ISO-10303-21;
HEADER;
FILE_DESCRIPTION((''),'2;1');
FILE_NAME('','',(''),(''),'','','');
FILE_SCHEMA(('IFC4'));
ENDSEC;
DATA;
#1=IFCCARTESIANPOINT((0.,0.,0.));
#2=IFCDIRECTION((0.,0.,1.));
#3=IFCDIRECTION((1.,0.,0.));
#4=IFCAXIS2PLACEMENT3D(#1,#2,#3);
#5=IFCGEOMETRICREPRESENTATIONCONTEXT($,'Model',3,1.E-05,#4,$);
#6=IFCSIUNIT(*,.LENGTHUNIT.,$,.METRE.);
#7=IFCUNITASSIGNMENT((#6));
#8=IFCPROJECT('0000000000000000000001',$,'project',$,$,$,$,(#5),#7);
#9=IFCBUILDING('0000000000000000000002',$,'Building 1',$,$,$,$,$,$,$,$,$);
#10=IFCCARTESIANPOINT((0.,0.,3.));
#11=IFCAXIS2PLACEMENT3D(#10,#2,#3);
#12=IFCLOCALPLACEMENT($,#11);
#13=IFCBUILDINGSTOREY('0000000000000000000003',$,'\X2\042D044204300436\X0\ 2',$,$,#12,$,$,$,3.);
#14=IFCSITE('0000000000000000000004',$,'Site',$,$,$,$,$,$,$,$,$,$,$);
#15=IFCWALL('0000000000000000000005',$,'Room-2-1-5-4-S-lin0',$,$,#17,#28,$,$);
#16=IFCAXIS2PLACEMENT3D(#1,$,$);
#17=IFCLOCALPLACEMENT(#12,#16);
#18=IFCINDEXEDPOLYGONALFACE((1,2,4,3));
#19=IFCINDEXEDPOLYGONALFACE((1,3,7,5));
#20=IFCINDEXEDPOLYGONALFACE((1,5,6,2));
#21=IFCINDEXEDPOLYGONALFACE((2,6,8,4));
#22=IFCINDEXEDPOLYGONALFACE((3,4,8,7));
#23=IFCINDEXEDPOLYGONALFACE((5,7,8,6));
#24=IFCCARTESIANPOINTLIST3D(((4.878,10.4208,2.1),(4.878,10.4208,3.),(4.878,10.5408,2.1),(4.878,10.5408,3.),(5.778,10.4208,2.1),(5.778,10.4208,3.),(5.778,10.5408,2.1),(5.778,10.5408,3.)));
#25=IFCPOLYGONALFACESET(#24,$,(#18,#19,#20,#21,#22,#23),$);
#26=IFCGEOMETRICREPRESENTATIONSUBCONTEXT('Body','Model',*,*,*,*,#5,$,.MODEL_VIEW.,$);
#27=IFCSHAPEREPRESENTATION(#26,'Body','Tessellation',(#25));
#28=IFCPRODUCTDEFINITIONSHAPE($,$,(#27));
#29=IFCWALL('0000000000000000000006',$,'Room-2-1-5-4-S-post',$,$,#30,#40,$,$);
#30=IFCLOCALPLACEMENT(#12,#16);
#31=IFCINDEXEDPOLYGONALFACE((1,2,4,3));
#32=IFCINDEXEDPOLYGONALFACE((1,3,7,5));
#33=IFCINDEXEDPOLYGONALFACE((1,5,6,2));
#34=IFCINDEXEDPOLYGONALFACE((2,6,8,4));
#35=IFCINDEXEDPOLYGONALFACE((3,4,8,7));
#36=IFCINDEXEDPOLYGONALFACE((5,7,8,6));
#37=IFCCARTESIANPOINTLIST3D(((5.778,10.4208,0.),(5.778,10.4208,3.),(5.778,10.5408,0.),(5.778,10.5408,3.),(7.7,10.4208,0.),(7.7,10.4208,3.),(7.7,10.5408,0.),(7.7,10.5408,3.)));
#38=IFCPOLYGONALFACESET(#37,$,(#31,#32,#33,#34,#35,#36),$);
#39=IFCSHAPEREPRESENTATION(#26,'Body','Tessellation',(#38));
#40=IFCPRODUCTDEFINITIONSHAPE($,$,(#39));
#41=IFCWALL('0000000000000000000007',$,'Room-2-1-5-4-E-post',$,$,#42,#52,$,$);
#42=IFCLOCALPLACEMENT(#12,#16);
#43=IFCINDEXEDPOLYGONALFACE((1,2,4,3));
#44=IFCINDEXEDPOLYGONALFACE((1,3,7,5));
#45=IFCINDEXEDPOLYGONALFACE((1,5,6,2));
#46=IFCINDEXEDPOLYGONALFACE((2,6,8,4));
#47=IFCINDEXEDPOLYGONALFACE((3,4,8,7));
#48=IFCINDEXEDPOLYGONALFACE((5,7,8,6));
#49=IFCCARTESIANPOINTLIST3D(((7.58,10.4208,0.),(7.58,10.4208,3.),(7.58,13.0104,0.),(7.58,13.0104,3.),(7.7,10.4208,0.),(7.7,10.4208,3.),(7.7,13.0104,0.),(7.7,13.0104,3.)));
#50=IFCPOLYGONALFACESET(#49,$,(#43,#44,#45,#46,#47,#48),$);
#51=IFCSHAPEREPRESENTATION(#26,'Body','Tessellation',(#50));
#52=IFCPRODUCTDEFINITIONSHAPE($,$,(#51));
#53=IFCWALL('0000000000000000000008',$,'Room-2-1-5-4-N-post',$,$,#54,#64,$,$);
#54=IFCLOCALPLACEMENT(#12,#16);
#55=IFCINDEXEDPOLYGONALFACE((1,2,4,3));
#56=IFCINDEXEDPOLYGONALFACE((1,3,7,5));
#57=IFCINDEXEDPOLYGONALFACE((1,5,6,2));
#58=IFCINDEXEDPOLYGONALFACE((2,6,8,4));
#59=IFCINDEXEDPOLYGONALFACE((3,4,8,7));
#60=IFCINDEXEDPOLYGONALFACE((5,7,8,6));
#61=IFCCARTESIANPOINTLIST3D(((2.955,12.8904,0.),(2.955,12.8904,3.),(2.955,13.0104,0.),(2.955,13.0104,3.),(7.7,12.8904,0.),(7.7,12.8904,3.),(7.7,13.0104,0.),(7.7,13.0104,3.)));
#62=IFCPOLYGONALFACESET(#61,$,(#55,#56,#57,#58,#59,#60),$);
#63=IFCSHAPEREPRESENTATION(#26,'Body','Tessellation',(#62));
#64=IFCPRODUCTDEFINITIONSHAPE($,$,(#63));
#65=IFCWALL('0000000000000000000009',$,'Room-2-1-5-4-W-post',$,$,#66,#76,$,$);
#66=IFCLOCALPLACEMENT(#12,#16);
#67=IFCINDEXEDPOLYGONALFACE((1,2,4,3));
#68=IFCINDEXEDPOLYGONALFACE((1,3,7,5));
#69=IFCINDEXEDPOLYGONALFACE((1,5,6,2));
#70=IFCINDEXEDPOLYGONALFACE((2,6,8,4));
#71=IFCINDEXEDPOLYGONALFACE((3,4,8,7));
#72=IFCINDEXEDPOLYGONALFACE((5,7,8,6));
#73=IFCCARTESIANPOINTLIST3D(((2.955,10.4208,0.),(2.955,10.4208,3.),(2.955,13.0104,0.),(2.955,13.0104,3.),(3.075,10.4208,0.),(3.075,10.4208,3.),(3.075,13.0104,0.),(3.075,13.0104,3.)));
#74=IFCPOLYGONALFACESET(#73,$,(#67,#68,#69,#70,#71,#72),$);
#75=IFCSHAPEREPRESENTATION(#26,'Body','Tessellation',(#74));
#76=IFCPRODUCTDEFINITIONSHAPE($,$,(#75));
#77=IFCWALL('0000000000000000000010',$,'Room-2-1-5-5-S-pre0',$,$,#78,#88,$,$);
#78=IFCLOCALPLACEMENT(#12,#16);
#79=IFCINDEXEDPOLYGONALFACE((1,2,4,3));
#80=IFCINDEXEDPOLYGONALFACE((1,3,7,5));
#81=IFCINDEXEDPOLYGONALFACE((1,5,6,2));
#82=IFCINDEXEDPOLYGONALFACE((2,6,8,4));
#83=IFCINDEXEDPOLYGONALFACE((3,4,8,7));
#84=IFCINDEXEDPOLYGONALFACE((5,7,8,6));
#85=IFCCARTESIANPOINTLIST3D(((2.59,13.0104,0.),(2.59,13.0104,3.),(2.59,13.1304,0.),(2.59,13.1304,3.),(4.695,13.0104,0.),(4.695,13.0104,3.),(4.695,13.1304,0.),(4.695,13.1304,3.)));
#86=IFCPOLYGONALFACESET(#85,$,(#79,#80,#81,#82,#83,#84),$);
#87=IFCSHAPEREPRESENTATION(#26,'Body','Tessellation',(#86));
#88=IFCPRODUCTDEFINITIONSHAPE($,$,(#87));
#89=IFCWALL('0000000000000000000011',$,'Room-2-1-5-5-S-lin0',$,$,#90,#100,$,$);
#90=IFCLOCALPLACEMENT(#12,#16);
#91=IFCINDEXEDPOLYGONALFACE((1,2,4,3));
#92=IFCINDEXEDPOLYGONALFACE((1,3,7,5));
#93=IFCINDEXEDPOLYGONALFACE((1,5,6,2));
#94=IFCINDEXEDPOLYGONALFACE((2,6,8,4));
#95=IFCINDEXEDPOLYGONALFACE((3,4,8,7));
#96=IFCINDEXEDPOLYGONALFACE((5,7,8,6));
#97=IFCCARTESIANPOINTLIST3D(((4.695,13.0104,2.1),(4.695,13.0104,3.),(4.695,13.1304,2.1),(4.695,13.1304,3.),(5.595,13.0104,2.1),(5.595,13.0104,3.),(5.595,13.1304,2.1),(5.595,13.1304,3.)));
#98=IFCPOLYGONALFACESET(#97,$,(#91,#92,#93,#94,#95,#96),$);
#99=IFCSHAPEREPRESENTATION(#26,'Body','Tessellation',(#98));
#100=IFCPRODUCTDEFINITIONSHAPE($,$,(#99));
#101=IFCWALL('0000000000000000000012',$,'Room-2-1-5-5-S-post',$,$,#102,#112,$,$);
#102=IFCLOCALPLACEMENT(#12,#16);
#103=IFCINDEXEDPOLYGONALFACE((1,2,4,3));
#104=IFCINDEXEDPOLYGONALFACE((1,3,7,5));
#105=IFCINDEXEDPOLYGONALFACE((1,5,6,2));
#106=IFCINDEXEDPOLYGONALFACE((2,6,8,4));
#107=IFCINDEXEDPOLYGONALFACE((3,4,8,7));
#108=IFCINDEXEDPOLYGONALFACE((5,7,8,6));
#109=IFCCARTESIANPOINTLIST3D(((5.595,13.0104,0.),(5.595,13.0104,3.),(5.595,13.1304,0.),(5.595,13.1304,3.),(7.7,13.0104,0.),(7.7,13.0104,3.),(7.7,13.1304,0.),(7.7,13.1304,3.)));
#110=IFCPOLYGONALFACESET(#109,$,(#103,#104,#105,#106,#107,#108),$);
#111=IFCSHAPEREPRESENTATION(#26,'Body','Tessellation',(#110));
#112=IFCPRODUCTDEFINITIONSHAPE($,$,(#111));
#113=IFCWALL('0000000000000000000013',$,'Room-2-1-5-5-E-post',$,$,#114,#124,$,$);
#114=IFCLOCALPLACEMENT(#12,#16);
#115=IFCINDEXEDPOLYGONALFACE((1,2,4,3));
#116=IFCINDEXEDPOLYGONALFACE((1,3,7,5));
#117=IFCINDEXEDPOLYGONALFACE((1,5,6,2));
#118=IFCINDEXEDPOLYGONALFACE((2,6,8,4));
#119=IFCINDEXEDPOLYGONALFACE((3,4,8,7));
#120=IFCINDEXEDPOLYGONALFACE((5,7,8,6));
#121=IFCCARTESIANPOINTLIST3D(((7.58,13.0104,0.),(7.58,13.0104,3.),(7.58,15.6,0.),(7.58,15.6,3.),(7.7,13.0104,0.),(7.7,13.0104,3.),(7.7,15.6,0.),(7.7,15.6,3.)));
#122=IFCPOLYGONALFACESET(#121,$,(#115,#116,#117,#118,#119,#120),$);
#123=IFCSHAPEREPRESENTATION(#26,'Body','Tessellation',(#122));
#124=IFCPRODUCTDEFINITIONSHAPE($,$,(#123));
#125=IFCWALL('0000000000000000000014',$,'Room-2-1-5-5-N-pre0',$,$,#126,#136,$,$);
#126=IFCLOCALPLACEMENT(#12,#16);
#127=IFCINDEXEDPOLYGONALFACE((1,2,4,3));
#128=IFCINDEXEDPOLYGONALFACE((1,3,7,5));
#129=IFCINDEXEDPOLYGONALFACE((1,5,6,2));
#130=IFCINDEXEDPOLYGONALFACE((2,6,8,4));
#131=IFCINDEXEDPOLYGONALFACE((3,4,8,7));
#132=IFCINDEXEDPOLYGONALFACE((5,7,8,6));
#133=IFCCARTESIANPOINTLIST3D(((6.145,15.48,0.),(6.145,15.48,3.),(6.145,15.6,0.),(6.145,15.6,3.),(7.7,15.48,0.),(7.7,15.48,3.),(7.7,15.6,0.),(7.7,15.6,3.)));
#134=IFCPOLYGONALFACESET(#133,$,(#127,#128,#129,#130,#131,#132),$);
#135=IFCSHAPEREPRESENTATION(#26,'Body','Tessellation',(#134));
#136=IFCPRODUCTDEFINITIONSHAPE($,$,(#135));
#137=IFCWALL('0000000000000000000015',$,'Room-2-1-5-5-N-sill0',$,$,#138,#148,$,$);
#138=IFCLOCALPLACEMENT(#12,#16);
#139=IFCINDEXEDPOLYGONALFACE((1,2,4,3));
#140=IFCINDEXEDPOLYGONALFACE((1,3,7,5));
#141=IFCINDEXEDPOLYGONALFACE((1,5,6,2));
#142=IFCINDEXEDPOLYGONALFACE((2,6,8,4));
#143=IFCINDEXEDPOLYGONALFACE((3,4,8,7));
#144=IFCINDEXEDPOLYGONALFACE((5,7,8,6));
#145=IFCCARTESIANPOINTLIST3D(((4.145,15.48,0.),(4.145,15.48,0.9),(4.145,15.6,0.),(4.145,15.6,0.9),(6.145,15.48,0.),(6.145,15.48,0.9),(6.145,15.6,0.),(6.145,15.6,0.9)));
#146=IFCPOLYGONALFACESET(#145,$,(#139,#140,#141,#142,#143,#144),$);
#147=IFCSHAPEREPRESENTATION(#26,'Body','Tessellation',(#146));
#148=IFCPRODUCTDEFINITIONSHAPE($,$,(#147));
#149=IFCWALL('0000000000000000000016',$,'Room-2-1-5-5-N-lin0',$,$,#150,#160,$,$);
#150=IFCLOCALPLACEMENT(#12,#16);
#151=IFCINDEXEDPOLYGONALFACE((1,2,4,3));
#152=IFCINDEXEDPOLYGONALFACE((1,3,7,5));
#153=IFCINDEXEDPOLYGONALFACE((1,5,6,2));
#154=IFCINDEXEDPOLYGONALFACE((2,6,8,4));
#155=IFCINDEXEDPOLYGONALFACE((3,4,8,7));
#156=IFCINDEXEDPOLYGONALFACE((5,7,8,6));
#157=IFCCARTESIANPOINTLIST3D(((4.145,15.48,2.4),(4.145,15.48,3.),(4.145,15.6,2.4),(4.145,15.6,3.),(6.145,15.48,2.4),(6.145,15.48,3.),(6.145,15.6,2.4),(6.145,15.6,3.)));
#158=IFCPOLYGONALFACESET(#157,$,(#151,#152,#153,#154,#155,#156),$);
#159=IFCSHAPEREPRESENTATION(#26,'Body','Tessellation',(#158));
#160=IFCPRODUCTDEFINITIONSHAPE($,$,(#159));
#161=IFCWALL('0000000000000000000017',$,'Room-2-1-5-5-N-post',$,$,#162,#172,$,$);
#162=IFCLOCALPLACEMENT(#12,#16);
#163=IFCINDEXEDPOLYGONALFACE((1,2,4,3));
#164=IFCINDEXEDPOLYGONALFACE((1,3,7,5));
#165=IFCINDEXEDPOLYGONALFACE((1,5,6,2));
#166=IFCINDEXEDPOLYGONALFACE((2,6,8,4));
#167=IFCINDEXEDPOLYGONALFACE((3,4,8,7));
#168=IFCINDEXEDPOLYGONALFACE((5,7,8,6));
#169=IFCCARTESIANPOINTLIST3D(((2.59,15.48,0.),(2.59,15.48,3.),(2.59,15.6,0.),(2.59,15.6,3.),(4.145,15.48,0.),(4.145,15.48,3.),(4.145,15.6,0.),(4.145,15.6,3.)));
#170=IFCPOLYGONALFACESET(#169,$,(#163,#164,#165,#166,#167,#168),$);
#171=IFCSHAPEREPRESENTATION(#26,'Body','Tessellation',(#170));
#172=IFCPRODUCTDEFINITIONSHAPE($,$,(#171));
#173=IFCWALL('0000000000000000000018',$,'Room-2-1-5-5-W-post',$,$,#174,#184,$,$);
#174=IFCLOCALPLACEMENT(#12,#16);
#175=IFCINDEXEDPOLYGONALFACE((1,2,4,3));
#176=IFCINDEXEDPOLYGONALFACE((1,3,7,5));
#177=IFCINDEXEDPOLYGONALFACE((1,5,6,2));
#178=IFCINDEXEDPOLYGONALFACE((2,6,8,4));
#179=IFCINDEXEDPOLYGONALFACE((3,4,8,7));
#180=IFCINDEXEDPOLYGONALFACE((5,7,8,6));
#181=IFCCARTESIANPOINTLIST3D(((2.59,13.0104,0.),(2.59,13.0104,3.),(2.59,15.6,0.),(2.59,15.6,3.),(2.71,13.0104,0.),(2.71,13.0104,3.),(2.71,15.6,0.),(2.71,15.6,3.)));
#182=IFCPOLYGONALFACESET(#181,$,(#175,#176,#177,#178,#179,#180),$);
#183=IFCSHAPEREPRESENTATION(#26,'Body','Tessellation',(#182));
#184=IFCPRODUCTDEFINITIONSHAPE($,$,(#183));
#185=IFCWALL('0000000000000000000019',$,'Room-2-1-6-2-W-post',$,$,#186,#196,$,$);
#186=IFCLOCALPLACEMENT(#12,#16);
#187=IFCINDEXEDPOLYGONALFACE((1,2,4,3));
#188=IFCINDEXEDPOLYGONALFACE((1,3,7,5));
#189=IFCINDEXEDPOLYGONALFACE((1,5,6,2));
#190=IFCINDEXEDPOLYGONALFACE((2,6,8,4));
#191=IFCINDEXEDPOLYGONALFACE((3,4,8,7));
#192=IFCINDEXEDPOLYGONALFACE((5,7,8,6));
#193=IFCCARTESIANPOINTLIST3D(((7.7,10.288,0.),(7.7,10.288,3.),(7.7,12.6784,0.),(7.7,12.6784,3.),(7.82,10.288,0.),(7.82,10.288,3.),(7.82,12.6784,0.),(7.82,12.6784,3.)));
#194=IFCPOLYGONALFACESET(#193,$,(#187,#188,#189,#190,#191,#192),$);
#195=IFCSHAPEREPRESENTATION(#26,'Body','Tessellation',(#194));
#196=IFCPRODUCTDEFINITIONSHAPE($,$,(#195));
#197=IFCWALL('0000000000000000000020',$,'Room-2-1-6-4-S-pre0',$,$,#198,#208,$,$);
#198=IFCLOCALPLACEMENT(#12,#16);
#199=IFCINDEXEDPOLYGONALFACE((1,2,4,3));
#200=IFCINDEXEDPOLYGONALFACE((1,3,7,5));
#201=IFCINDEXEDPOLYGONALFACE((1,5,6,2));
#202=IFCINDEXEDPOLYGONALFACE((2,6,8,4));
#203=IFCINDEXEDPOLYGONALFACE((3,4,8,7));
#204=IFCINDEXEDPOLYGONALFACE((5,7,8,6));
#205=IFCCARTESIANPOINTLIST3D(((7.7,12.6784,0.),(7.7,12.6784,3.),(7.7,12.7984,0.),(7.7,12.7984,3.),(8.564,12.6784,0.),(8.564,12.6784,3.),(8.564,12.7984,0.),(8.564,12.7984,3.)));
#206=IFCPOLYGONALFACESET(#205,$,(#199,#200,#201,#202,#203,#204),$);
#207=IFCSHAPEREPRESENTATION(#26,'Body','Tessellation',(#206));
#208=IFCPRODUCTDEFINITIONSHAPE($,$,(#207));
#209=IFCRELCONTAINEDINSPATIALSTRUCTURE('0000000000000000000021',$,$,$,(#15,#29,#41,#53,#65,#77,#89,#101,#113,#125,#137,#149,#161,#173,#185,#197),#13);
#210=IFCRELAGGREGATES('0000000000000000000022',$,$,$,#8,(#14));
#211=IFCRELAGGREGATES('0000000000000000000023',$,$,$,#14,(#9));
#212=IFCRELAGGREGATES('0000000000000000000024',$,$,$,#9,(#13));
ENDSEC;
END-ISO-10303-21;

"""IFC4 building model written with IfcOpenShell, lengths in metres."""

from ifc_helpers import new_model, si_unit, frame, origin_with_axes, place, context, subcontext, project, spatial, indexed_curve, outline, extrude, element, save


model = new_model("IFC4")

# Units and contexts
model_context = context("Model", 3, precision=1e-05, world=origin_with_axes())
body_context = subcontext(model_context, "Body", "Model", "MODEL_VIEW")
ifc_project = project(units=[si_unit("LENGTHUNIT", "METRE")], contexts=[model_context])

# Site, building, storey
site = spatial("IfcSite", under=ifc_project, Name="Site")
building = spatial("IfcBuilding", under=site, Name="Building 1")
storey_placement = place(None, frame((0.0, 0.0, 3.0), z_axis=(0.0, 0.0, 1.0), x_axis=(1.0, 0.0, 0.0)))
storey = spatial("IfcBuildingStorey", under=building, at=storey_placement, Name="Этаж 2", Elevation=3.0)

# Walls
wall_1_placement = place(storey_placement, frame((4.878, 10.4208, 2.1), z_axis=(0.0, 0.0, 1.0), x_axis=(1.0, 0.0, 0.0)))
element("IfcWall", 1, at=wall_1_placement, inside=storey, Name="Room-2-1-5-4-S-lin0", context=body_context, shape_type="SweptSolid", body=[
    extrude(outline(indexed_curve([(0.0, 0.0), (0.0, 0.12), (0.9, 0.12), (0.9, 0.0), (0.0, 0.0)], self_intersect=False)), origin_with_axes(), (0.0, 0.0, 1.0), 0.9),
])
wall_2_placement = place(storey_placement, frame((5.778, 10.4208, 0.0), z_axis=(0.0, 0.0, 1.0), x_axis=(1.0, 0.0, 0.0)))
element("IfcWall", 2, at=wall_2_placement, inside=storey, Name="Room-2-1-5-4-S-post", context=body_context, shape_type="SweptSolid", body=[
    extrude(outline(indexed_curve([(0.0, 0.0), (0.0, 0.12), (1.922, 0.12), (1.922, 0.0), (0.0, 0.0)], self_intersect=False)), origin_with_axes(), (0.0, 0.0, 1.0), 3.0),
])
wall_3_placement = place(storey_placement, frame((7.7, 10.4208, 0.0), z_axis=(0.0, 0.0, 1.0), x_axis=(0.0, 1.0, 0.0)))
element("IfcWall", 3, at=wall_3_placement, inside=storey, Name="Room-2-1-5-4-E-post", context=body_context, shape_type="SweptSolid", body=[
    extrude(outline(indexed_curve([(0.0, 0.0), (0.0, 0.12), (2.5896, 0.12), (2.5896, 0.0), (0.0, 0.0)], self_intersect=False)), origin_with_axes(), (0.0, 0.0, 1.0), 3.0),
])
wall_4_placement = place(storey_placement, frame((7.7, 13.0104, 0.0), z_axis=(0.0, 0.0, 1.0), x_axis=(-1.0, 0.0, 0.0)))
element("IfcWall", 4, at=wall_4_placement, inside=storey, Name="Room-2-1-5-4-N-post", context=body_context, shape_type="SweptSolid", body=[
    extrude(outline(indexed_curve([(0.0, 0.0), (0.0, 0.12), (4.745, 0.12), (4.745, 0.0), (0.0, 0.0)], self_intersect=False)), origin_with_axes(), (0.0, 0.0, 1.0), 3.0),
])
wall_5_placement = place(storey_placement, frame((2.955, 13.0104, 0.0), z_axis=(0.0, 0.0, 1.0), x_axis=(0.0, -1.0, 0.0)))
element("IfcWall", 5, at=wall_5_placement, inside=storey, Name="Room-2-1-5-4-W-post", context=body_context, shape_type="SweptSolid", body=[
    extrude(outline(indexed_curve([(0.0, 0.0), (0.0, 0.12), (2.5896, 0.12), (2.5896, 0.0), (0.0, 0.0)], self_intersect=False)), origin_with_axes(), (0.0, 0.0, 1.0), 3.0),
])
wall_6_placement = place(storey_placement, frame((2.59, 13.0104, 0.0), z_axis=(0.0, 0.0, 1.0), x_axis=(1.0, 0.0, 0.0)))
element("IfcWall", 6, at=wall_6_placement, inside=storey, Name="Room-2-1-5-5-S-pre0", context=body_context, shape_type="SweptSolid", body=[
    extrude(outline(indexed_curve([(0.0, 0.0), (0.0, 0.12), (2.105, 0.12), (2.105, 0.0), (0.0, 0.0)], self_intersect=False)), origin_with_axes(), (0.0, 0.0, 1.0), 3.0),
])
wall_7_placement = place(storey_placement, frame((4.695, 13.0104, 2.1), z_axis=(0.0, 0.0, 1.0), x_axis=(1.0, 0.0, 0.0)))
element("IfcWall", 7, at=wall_7_placement, inside=storey, Name="Room-2-1-5-5-S-lin0", context=body_context, shape_type="SweptSolid", body=[
    extrude(outline(indexed_curve([(0.0, 0.0), (0.0, 0.12), (0.9, 0.12), (0.9, 0.0), (0.0, 0.0)], self_intersect=False)), origin_with_axes(), (0.0, 0.0, 1.0), 0.9),
])
wall_8_placement = place(storey_placement, frame((5.595, 13.0104, 0.0), z_axis=(0.0, 0.0, 1.0), x_axis=(1.0, 0.0, 0.0)))
element("IfcWall", 8, at=wall_8_placement, inside=storey, Name="Room-2-1-5-5-S-post", context=body_context, shape_type="SweptSolid", body=[
    extrude(outline(indexed_curve([(0.0, 0.0), (0.0, 0.12), (2.105, 0.12), (2.105, 0.0), (0.0, 0.0)], self_intersect=False)), origin_with_axes(), (0.0, 0.0, 1.0), 3.0),
])
wall_9_placement = place(storey_placement, frame((7.7, 13.0104, 0.0), z_axis=(0.0, 0.0, 1.0), x_axis=(0.0, 1.0, 0.0)))
element("IfcWall", 9, at=wall_9_placement, inside=storey, Name="Room-2-1-5-5-E-post", context=body_context, shape_type="SweptSolid", body=[
    extrude(outline(indexed_curve([(0.0, 0.0), (0.0, 0.12), (2.5896, 0.12), (2.5896, 0.0), (0.0, 0.0)], self_intersect=False)), origin_with_axes(), (0.0, 0.0, 1.0), 3.0),
])
wall_10_placement = place(storey_placement, frame((7.7, 15.6, 0.0), z_axis=(0.0, 0.0, 1.0), x_axis=(-1.0, 0.0, 0.0)))
element("IfcWall", 10, at=wall_10_placement, inside=storey, Name="Room-2-1-5-5-N-pre0", context=body_context, shape_type="SweptSolid", body=[
    extrude(outline(indexed_curve([(0.0, 0.0), (0.0, 0.12), (1.555, 0.12), (1.555, 0.0), (0.0, 0.0)], self_intersect=False)), origin_with_axes(), (0.0, 0.0, 1.0), 3.0),
])
wall_11_placement = place(storey_placement, frame((6.145, 15.6, 0.0), z_axis=(0.0, 0.0, 1.0), x_axis=(-1.0, 0.0, 0.0)))
element("IfcWall", 11, at=wall_11_placement, inside=storey, Name="Room-2-1-5-5-N-sill0", context=body_context, shape_type="SweptSolid", body=[
    extrude(outline(indexed_curve([(0.0, 0.0), (0.0, 0.12), (2.0, 0.12), (2.0, 0.0), (0.0, 0.0)], self_intersect=False)), origin_with_axes(), (0.0, 0.0, 1.0), 0.9),
])
wall_12_placement = place(storey_placement, frame((6.145, 15.6, 2.4), z_axis=(0.0, 0.0, 1.0), x_axis=(-1.0, 0.0, 0.0)))
element("IfcWall", 12, at=wall_12_placement, inside=storey, Name="Room-2-1-5-5-N-lin0", context=body_context, shape_type="SweptSolid", body=[
    extrude(outline(indexed_curve([(0.0, 0.0), (0.0, 0.12), (2.0, 0.12), (2.0, 0.0), (0.0, 0.0)], self_intersect=False)), origin_with_axes(), (0.0, 0.0, 1.0), 0.6),
])
wall_13_placement = place(storey_placement, frame((4.145, 15.6, 0.0), z_axis=(0.0, 0.0, 1.0), x_axis=(-1.0, 0.0, 0.0)))
element("IfcWall", 13, at=wall_13_placement, inside=storey, Name="Room-2-1-5-5-N-post", context=body_context, shape_type="SweptSolid", body=[
    extrude(outline(indexed_curve([(0.0, 0.0), (0.0, 0.12), (1.555, 0.12), (1.555, 0.0), (0.0, 0.0)], self_intersect=False)), origin_with_axes(), (0.0, 0.0, 1.0), 3.0),
])
wall_14_placement = place(storey_placement, frame((2.59, 15.6, 0.0), z_axis=(0.0, 0.0, 1.0), x_axis=(0.0, -1.0, 0.0)))
element("IfcWall", 14, at=wall_14_placement, inside=storey, Name="Room-2-1-5-5-W-post", context=body_context, shape_type="SweptSolid", body=[
    extrude(outline(indexed_curve([(0.0, 0.0), (0.0, 0.12), (2.5896, 0.12), (2.5896, 0.0), (0.0, 0.0)], self_intersect=False)), origin_with_axes(), (0.0, 0.0, 1.0), 3.0),
])
wall_15_placement = place(storey_placement, frame((7.7, 12.6784, 0.0), z_axis=(0.0, 0.0, 1.0), x_axis=(0.0, -1.0, 0.0)))
element("IfcWall", 15, at=wall_15_placement, inside=storey, Name="Room-2-1-6-2-W-post", context=body_context, shape_type="SweptSolid", body=[
    extrude(outline(indexed_curve([(0.0, 0.0), (0.0, 0.12), (2.3904, 0.12), (2.3904, 0.0), (0.0, 0.0)], self_intersect=False)), origin_with_axes(), (0.0, 0.0, 1.0), 3.0),
])
wall_16_placement = place(storey_placement, frame((7.7, 12.6784, 0.0), z_axis=(0.0, 0.0, 1.0), x_axis=(1.0, 0.0, 0.0)))
element("IfcWall", 16, at=wall_16_placement, inside=storey, Name="Room-2-1-6-4-S-pre0", context=body_context, shape_type="SweptSolid", body=[
    extrude(outline(indexed_curve([(0.0, 0.0), (0.0, 0.12), (0.864, 0.12), (0.864, 0.0), (0.0, 0.0)], self_intersect=False)), origin_with_axes(), (0.0, 0.0, 1.0), 3.0),
])

save(model, "model.ifc")
